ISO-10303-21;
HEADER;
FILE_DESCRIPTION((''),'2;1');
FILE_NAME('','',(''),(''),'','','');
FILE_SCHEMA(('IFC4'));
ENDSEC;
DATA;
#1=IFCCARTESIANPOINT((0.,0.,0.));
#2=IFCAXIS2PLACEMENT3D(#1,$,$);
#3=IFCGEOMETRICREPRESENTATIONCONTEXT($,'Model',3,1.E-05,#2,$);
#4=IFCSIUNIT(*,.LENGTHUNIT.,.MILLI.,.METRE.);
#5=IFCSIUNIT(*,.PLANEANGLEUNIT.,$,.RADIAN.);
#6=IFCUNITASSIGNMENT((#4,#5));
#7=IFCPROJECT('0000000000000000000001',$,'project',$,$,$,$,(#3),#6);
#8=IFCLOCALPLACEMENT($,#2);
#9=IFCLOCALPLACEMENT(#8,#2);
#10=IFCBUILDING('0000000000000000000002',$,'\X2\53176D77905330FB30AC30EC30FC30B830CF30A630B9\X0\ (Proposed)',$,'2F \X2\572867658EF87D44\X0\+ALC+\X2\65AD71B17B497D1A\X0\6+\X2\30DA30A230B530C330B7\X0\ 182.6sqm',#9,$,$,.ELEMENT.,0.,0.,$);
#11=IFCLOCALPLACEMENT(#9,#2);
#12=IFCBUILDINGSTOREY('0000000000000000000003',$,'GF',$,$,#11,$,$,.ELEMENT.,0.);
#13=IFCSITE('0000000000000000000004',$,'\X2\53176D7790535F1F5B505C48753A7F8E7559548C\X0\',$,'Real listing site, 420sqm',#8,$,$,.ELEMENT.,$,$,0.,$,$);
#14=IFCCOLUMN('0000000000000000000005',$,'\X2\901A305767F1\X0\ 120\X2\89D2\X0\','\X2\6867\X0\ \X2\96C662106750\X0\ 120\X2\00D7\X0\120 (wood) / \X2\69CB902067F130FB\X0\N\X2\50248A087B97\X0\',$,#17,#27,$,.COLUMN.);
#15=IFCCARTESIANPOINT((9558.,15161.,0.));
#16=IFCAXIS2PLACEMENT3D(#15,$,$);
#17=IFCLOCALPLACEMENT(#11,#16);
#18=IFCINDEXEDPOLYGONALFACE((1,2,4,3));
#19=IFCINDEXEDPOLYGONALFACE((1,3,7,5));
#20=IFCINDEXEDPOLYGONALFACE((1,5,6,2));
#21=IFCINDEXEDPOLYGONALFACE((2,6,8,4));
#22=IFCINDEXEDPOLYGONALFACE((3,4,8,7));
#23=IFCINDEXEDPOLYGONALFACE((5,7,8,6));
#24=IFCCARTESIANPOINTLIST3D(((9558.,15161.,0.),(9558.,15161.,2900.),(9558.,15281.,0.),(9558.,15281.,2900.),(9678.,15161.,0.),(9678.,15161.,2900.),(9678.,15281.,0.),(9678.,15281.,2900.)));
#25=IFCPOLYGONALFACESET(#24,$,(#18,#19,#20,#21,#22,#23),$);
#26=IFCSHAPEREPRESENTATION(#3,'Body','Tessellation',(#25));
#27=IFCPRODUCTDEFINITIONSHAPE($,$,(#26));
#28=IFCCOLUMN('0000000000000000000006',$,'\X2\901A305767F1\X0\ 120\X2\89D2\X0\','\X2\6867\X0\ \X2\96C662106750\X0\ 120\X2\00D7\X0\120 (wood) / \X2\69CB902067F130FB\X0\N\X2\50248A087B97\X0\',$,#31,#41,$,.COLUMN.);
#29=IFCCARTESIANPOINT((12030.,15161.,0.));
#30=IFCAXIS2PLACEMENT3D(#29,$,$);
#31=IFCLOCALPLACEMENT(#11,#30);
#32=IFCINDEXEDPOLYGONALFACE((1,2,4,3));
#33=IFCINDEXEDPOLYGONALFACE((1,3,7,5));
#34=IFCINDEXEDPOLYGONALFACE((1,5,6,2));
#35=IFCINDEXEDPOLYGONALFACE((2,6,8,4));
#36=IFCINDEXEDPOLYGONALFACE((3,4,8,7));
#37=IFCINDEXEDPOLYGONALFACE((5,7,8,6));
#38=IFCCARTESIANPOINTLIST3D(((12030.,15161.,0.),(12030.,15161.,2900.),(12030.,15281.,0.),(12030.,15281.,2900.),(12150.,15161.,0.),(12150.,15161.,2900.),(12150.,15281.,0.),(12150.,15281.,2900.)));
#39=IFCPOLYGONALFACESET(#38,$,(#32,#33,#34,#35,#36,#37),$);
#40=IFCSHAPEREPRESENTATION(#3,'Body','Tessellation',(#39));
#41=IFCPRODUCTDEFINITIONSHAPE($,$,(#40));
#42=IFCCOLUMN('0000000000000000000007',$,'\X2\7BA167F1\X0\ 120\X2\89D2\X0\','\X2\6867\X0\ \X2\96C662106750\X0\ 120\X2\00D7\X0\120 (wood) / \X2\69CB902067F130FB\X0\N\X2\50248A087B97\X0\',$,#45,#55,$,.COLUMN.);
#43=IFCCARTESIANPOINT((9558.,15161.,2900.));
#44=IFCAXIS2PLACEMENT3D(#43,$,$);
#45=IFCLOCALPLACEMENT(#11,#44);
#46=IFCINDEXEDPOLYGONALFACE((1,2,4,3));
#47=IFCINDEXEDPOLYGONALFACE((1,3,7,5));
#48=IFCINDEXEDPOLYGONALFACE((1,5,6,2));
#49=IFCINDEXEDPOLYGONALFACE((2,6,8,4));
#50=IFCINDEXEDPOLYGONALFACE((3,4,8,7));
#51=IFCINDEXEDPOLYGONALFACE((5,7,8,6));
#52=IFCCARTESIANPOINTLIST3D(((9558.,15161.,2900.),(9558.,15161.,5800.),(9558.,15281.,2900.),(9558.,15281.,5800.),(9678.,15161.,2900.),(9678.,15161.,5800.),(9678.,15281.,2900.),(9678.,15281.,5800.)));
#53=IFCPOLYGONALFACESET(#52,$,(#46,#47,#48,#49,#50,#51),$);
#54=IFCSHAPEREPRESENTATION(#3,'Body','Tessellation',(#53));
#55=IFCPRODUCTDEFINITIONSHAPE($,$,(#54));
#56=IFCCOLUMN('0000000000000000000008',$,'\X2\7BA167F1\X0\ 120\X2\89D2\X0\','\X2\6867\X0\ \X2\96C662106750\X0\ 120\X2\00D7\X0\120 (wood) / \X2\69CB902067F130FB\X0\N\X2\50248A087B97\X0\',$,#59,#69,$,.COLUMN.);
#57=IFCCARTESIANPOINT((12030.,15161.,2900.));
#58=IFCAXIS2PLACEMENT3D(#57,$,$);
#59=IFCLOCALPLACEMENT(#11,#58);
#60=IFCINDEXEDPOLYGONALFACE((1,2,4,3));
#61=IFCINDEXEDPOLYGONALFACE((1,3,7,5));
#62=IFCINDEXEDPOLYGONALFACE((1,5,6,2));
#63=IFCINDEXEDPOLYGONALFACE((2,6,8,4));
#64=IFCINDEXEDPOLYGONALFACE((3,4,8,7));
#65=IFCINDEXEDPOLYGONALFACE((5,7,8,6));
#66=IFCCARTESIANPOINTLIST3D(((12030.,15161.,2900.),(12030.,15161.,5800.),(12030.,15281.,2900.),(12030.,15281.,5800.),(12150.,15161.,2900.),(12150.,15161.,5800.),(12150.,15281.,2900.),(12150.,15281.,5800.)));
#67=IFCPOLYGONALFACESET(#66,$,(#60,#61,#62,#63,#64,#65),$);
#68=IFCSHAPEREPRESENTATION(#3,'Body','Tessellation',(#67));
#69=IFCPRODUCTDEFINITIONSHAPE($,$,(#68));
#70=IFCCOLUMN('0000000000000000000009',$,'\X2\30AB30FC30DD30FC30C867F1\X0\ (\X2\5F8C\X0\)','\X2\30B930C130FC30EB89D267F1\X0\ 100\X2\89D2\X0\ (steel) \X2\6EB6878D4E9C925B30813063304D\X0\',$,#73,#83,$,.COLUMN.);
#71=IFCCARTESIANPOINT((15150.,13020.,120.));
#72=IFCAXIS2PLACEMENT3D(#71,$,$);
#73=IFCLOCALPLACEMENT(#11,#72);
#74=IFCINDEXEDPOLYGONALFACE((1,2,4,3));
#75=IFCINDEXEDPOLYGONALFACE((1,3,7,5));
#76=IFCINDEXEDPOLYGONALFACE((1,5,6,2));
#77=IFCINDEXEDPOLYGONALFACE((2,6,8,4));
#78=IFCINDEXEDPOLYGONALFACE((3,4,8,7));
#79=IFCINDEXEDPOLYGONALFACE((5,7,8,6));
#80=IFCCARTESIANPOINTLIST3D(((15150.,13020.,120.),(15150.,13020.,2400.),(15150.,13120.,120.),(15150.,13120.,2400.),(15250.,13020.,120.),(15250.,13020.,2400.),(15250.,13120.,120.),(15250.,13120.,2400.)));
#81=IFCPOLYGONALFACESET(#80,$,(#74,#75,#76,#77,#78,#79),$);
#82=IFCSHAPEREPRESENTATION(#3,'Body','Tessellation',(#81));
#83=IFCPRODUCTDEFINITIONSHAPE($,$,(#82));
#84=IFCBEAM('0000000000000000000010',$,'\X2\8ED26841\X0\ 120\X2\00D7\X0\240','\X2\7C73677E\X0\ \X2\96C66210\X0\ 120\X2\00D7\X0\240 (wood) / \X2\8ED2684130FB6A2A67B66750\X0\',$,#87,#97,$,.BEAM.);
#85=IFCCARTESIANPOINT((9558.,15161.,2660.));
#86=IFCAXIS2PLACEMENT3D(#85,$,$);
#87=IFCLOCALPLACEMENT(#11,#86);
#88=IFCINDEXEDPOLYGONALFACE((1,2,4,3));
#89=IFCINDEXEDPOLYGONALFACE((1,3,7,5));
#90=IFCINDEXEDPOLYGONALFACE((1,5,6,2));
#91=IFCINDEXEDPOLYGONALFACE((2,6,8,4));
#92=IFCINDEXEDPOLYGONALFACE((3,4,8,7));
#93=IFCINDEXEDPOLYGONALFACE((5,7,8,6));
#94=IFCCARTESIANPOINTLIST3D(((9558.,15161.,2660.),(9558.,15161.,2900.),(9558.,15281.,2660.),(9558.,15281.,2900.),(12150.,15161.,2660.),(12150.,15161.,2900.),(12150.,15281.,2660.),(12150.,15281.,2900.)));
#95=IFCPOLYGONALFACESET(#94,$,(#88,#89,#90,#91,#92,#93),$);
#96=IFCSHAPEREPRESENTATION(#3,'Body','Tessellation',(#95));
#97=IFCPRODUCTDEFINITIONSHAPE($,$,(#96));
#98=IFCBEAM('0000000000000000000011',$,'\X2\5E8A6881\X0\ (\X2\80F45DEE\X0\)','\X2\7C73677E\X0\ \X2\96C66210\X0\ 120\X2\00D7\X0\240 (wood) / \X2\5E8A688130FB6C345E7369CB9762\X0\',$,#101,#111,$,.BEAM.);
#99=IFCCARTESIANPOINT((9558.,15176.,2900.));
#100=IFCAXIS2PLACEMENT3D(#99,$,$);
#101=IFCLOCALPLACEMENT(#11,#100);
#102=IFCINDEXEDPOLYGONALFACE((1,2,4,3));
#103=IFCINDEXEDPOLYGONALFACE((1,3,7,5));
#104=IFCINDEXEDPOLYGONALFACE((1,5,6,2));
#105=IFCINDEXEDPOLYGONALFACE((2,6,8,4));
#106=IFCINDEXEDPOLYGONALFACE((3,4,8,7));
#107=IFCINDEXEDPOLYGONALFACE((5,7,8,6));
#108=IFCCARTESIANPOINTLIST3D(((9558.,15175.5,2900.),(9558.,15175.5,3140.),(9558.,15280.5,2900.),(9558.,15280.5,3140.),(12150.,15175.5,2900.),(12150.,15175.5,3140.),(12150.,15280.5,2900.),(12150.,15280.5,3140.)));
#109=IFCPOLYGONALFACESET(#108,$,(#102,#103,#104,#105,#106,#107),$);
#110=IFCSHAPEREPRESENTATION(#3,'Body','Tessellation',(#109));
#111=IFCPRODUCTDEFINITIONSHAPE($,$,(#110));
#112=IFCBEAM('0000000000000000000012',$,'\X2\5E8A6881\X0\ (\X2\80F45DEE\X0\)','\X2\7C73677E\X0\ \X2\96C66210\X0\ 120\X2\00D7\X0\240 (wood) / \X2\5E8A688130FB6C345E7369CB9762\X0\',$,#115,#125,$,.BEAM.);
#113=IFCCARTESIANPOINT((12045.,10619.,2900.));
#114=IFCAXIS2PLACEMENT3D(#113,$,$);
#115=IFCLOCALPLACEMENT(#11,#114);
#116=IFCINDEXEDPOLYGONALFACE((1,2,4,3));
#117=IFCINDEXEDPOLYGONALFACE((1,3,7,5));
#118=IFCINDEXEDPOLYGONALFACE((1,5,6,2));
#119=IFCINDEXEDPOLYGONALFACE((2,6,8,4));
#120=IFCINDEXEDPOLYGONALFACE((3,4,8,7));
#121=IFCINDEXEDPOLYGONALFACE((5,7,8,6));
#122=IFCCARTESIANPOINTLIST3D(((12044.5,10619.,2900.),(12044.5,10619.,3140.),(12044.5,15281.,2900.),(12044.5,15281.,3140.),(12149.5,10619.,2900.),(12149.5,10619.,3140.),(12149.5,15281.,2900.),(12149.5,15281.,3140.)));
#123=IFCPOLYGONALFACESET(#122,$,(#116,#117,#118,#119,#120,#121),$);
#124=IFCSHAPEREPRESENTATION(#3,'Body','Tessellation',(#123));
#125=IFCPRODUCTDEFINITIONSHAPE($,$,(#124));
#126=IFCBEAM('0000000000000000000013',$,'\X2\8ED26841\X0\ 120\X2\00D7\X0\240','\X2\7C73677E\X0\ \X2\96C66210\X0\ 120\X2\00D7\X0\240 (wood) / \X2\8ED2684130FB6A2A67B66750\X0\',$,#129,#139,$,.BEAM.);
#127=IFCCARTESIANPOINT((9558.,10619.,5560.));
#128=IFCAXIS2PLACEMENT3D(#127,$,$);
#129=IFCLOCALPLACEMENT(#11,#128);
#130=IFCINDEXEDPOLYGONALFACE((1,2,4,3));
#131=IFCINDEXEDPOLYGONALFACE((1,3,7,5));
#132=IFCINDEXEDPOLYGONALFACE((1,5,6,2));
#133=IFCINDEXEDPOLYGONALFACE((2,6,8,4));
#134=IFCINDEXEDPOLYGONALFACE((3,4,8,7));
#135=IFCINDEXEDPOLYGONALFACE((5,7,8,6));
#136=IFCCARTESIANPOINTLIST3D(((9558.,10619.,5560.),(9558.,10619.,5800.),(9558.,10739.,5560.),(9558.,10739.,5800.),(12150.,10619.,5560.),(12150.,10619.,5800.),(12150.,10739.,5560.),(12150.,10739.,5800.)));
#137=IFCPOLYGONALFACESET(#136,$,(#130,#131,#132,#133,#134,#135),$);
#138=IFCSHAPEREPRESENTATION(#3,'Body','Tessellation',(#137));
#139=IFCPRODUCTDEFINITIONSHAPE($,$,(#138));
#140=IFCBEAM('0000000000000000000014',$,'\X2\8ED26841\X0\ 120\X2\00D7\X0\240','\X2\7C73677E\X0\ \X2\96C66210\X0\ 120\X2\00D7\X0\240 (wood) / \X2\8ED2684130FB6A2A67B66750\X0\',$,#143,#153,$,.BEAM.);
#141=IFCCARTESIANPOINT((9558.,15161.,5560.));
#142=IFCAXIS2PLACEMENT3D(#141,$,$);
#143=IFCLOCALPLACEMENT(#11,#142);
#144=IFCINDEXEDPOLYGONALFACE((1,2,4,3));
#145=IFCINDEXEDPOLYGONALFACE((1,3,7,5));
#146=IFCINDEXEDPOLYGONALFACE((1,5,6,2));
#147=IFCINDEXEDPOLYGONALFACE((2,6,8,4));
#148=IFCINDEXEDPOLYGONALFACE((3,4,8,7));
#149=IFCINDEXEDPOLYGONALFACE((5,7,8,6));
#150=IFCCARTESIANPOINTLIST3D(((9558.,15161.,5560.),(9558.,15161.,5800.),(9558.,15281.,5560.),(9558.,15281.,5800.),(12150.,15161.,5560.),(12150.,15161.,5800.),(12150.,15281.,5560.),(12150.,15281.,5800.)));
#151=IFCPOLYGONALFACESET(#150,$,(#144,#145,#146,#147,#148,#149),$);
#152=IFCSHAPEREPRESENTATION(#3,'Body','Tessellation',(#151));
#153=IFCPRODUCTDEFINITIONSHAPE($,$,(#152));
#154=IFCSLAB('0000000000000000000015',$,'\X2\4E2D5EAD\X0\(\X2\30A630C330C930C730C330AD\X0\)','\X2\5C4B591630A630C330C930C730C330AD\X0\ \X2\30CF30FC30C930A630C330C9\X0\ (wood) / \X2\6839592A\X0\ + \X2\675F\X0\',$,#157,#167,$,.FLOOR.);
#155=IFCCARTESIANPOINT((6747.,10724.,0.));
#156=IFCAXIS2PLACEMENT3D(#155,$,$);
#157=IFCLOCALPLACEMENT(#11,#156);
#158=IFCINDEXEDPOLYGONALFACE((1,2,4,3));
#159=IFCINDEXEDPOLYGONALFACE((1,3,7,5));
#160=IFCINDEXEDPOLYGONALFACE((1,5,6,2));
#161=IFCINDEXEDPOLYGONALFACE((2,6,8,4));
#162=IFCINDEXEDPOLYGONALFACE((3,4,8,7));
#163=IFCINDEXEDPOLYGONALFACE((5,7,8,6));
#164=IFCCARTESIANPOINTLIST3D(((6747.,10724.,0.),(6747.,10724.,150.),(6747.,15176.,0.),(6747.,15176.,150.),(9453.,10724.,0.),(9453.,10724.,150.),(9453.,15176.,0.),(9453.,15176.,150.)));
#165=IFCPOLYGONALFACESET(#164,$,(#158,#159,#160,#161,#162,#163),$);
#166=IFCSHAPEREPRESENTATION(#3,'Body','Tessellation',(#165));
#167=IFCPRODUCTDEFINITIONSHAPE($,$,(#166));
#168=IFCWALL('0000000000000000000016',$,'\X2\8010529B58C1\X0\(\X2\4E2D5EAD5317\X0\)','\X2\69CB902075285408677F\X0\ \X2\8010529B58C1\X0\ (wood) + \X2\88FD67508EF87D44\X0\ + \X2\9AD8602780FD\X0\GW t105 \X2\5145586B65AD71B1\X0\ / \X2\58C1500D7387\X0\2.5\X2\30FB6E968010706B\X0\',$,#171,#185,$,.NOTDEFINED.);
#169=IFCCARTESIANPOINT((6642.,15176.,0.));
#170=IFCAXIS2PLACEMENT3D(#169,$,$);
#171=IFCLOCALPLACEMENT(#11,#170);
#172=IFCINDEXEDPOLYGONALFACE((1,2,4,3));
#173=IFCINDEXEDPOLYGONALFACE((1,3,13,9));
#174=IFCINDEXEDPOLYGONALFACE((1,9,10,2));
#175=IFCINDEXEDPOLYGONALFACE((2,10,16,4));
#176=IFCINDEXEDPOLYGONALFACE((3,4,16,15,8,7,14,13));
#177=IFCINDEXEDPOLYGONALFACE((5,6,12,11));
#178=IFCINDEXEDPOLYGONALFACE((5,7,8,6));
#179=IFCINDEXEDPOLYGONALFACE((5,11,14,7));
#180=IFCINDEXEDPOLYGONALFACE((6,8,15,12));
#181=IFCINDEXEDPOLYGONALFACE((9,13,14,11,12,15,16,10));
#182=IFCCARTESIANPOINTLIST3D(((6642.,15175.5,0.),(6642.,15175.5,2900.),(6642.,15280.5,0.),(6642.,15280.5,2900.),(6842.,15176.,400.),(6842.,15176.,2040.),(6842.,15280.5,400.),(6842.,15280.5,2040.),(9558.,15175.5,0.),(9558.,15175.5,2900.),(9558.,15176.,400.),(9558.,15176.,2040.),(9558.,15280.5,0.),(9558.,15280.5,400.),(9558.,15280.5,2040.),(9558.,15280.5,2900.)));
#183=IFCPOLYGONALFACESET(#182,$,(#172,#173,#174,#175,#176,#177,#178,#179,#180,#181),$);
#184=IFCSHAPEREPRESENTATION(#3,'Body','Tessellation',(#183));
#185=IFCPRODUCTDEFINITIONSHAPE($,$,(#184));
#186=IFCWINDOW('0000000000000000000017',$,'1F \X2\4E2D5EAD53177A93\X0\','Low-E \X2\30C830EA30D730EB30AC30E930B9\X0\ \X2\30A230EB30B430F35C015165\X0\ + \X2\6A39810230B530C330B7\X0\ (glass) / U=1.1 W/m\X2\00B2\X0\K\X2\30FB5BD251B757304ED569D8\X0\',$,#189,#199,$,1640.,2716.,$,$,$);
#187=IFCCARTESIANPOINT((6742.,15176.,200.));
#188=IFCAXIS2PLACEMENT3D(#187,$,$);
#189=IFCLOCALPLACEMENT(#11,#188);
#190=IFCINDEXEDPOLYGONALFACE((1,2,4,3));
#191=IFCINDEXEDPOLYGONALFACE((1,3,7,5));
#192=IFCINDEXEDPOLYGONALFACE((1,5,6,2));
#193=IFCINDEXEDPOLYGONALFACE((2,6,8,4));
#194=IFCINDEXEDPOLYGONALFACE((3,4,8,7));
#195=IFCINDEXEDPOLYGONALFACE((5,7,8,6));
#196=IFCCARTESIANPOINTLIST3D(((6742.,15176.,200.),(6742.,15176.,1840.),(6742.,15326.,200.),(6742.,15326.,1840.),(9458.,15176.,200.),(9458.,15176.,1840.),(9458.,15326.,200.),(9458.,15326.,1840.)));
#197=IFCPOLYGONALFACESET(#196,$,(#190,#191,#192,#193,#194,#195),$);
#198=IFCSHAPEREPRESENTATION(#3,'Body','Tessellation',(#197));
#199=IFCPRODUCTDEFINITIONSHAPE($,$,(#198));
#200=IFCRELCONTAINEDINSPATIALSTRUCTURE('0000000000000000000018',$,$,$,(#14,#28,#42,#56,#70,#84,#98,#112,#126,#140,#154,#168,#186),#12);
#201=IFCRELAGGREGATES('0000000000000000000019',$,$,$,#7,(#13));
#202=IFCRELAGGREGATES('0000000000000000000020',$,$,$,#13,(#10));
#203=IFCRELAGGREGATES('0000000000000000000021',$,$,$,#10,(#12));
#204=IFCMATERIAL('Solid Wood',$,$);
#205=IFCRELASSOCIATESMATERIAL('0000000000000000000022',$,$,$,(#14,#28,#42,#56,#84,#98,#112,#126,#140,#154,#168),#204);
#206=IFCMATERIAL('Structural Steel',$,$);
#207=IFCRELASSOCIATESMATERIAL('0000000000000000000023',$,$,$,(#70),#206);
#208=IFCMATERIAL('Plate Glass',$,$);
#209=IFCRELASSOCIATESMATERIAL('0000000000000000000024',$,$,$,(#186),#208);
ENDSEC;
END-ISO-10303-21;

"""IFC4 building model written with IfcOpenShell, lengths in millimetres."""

from ifc_helpers import new_model, si_unit, frame, frame_2d, origin, place, context, project, spatial, rectangle, extrude, material, element, fill, save


model = new_model("IFC4")

# Units and contexts
model_context = context("Model", 3, precision=1e-05, world=origin())
ifc_project = project(units=[si_unit("LENGTHUNIT", "METRE", prefix="MILLI"), si_unit("PLANEANGLEUNIT", "RADIAN")], contexts=[model_context])

# Site, building, storey
site_placement = place(None, origin())
site = spatial("IfcSite", under=ifc_project, at=site_placement, Name="北海道弟子屈町美留和", ObjectType="Real listing site, 420sqm", CompositionType="ELEMENT", RefElevation=0.0)
building_placement = place(site_placement, origin())
building = spatial("IfcBuilding", under=site, at=building_placement, Name="北海道・ガレージハウス (Proposed)", ObjectType="2F 在来軸組+ALC+断熱等級6+ペアサッシ 182.6sqm", CompositionType="ELEMENT", ElevationOfRefHeight=0.0, ElevationOfTerrain=0.0)
storey_placement = place(building_placement, origin())
storey = spatial("IfcBuildingStorey", under=building, at=storey_placement, Name="GF", CompositionType="ELEMENT", Elevation=0.0)

# Columns
ifc_material_1 = material(Name="Solid Wood")
column_1_placement = place(storey_placement, frame((9558.0, 15161.0, 0.0)))
element("IfcColumn", 1, at=column_1_placement, inside=storey, material=ifc_material_1, Name="通し柱 120角", Description="桧 集成材 120×120 (wood) / 構造柱・N値計算", PredefinedType="COLUMN", context=model_context, shape_type="SweptSolid", body=[
    extrude(rectangle(XDim=120.0, YDim=120.0, at=frame_2d((60.0, 60.0))), frame((9558.0, 15161.0, 0.0)), (0.0, 0.0, 1.0), 2900.0),
])
column_2_placement = place(storey_placement, frame((12030.0, 15161.0, 0.0)))
element("IfcColumn", 2, at=column_2_placement, inside=storey, material=ifc_material_1, Name="通し柱 120角", Description="桧 集成材 120×120 (wood) / 構造柱・N値計算", PredefinedType="COLUMN", context=model_context, shape_type="SweptSolid", body=[
    extrude(rectangle(XDim=120.0, YDim=120.0, at=frame_2d((60.0, 60.0))), frame((12030.0, 15161.0, 0.0)), (0.0, 0.0, 1.0), 2900.0),
])
column_3_placement = place(storey_placement, frame((9558.0, 15161.0, 2900.0)))
element("IfcColumn", 3, at=column_3_placement, inside=storey, material=ifc_material_1, Name="管柱 120角", Description="桧 集成材 120×120 (wood) / 構造柱・N値計算", PredefinedType="COLUMN", context=model_context, shape_type="SweptSolid", body=[
    extrude(rectangle(XDim=120.0, YDim=120.0, at=frame_2d((60.0, 60.0))), frame((9558.0, 15161.0, 2900.0)), (0.0, 0.0, 1.0), 2900.0),
])
column_4_placement = place(storey_placement, frame((12030.0, 15161.0, 2900.0)))
element("IfcColumn", 4, at=column_4_placement, inside=storey, material=ifc_material_1, Name="管柱 120角", Description="桧 集成材 120×120 (wood) / 構造柱・N値計算", PredefinedType="COLUMN", context=model_context, shape_type="SweptSolid", body=[
    extrude(rectangle(XDim=120.0, YDim=120.0, at=frame_2d((60.0, 60.0))), frame((12030.0, 15161.0, 2900.0)), (0.0, 0.0, 1.0), 2900.0),
])
ifc_material_2 = material(Name="Structural Steel")
column_5_placement = place(storey_placement, frame((15150.0, 13020.0, 120.0)))
element("IfcColumn", 5, at=column_5_placement, inside=storey, material=ifc_material_2, Name="カーポート柱 (後)", Description="スチール角柱 100角 (steel) 溶融亜鉛めっき", PredefinedType="COLUMN", context=model_context, shape_type="SweptSolid", body=[
    extrude(rectangle(XDim=100.0, YDim=100.0, at=frame_2d((50.0, 50.0))), frame((15150.0, 13020.0, 120.0)), (0.0, 0.0, 1.0), 2280.0),
])

# Beams
beam_1_placement = place(storey_placement, frame((9558.0, 15161.0, 2660.0)))
element("IfcBeam", 6, at=beam_1_placement, inside=storey, material=ifc_material_1, Name="軒桁 120×240", Description="米松 集成 120×240 (wood) / 軒桁・横架材", PredefinedType="BEAM", context=model_context, shape_type="SweptSolid", body=[
    extrude(rectangle(XDim=2592.0, YDim=120.0, at=frame_2d((1296.0, 60.0))), frame((9558.0, 15161.0, 2660.0)), (0.0, 0.0, 1.0), 240.0),
])
beam_2_placement = place(storey_placement, frame((9558.0, 15176.0, 2900.0)))
element("IfcBeam", 7, at=beam_2_placement, inside=storey, material=ifc_material_1, Name="床梁 (胴差)", Description="米松 集成 120×240 (wood) / 床梁・水平構面", PredefinedType="BEAM", context=model_context, shape_type="SweptSolid", body=[
    extrude(rectangle(XDim=2592.0, YDim=105.0, at=frame_2d((1296.0, 52.0))), frame((9558.0, 15176.0, 2900.0)), (0.0, 0.0, 1.0), 240.0),
])
beam_3_placement = place(storey_placement, frame((12045.0, 10619.0, 2900.0)))
element("IfcBeam", 8, at=beam_3_placement, inside=storey, material=ifc_material_1, Name="床梁 (胴差)", Description="米松 集成 120×240 (wood) / 床梁・水平構面", PredefinedType="BEAM", context=model_context, shape_type="SweptSolid", body=[
    extrude(rectangle(XDim=105.0, YDim=4662.0, at=frame_2d((52.0, 2331.0))), frame((12045.0, 10619.0, 2900.0)), (0.0, 0.0, 1.0), 240.0),
])
beam_4_placement = place(storey_placement, frame((9558.0, 10619.0, 5560.0)))
element("IfcBeam", 9, at=beam_4_placement, inside=storey, material=ifc_material_1, Name="軒桁 120×240", Description="米松 集成 120×240 (wood) / 軒桁・横架材", PredefinedType="BEAM", context=model_context, shape_type="SweptSolid", body=[
    extrude(rectangle(XDim=2592.0, YDim=120.0, at=frame_2d((1296.0, 60.0))), frame((9558.0, 10619.0, 5560.0)), (0.0, 0.0, 1.0), 240.0),
])
beam_5_placement = place(storey_placement, frame((9558.0, 15161.0, 5560.0)))
element("IfcBeam", 10, at=beam_5_placement, inside=storey, material=ifc_material_1, Name="軒桁 120×240", Description="米松 集成 120×240 (wood) / 軒桁・横架材", PredefinedType="BEAM", context=model_context, shape_type="SweptSolid", body=[
    extrude(rectangle(XDim=2592.0, YDim=120.0, at=frame_2d((1296.0, 60.0))), frame((9558.0, 15161.0, 5560.0)), (0.0, 0.0, 1.0), 240.0),
])

# Slab
slab_placement = place(storey_placement, frame((6747.0, 10724.0, 0.0)))
element("IfcSlab", 11, at=slab_placement, inside=storey, material=ifc_material_1, Name="中庭(ウッドデッキ)", Description="屋外ウッドデッキ ハードウッド (wood) / 根太 + 束", PredefinedType="FLOOR", context=model_context, shape_type="SweptSolid", body=[
    extrude(rectangle(XDim=2706.0, YDim=4452.0, at=frame_2d((1353.0, 2226.0))), frame((6747.0, 10724.0, 0.0)), (0.0, 0.0, 1.0), 150.0),
])

# Wall, opening, window
wall_1_placement = place(storey_placement, frame((6642.0, 15176.0, 0.0)))
wall_1 = element("IfcWall", 12, at=wall_1_placement, inside=storey, material=ifc_material_1, Name="耐力壁(中庭北)", Description="構造用合板 耐力壁 (wood) + 製材軸組 + 高性能GW t105 充填断熱 / 壁倍率2.5・準耐火", PredefinedType="NOTDEFINED", context=model_context, shape_type="SweptSolid", body=[
    extrude(rectangle(XDim=2916.0, YDim=105.0, at=frame_2d((1458.0, 52.0))), frame((6642.0, 15176.0, 0.0)), (0.0, 0.0, 1.0), 2900.0),
])
opening_1_placement = place(storey_placement, frame((6742.0, 15176.0, 200.0)))
opening_1 = element("IfcOpeningElement", 13, at=opening_1_placement, cuts=wall_1, PredefinedType="NOTDEFINED", context=model_context, shape_type="SweptSolid", body=[
    extrude(rectangle(XDim=2716.0, YDim=150.0, at=frame_2d((1358.0, 75.0))), frame((6742.0, 15176.0, 200.0)), (0.0, 0.0, 1.0), 1640.0),
])
ifc_material_3 = material(Name="Plate Glass")
window_1_placement = place(storey_placement, frame((6742.0, 15176.0, 200.0)))
window_1 = element("IfcWindow", 14, at=window_1_placement, inside=storey, material=ifc_material_3, Name="1F 中庭北窓", Description="Low-E トリプルガラス アルゴン封入 + 樹脂サッシ (glass) / U=1.1 W/m²K・寒冷地仕様", OverallHeight=1640.0, OverallWidth=2716.0, context=model_context, shape_type="SweptSolid", body=[
    extrude(rectangle(XDim=2716.0, YDim=150.0, at=frame_2d((1358.0, 75.0))), frame((6742.0, 15176.0, 200.0)), (0.0, 0.0, 1.0), 1640.0),
])
fill(opening_1, window_1)

save(model, "model.ifc")
